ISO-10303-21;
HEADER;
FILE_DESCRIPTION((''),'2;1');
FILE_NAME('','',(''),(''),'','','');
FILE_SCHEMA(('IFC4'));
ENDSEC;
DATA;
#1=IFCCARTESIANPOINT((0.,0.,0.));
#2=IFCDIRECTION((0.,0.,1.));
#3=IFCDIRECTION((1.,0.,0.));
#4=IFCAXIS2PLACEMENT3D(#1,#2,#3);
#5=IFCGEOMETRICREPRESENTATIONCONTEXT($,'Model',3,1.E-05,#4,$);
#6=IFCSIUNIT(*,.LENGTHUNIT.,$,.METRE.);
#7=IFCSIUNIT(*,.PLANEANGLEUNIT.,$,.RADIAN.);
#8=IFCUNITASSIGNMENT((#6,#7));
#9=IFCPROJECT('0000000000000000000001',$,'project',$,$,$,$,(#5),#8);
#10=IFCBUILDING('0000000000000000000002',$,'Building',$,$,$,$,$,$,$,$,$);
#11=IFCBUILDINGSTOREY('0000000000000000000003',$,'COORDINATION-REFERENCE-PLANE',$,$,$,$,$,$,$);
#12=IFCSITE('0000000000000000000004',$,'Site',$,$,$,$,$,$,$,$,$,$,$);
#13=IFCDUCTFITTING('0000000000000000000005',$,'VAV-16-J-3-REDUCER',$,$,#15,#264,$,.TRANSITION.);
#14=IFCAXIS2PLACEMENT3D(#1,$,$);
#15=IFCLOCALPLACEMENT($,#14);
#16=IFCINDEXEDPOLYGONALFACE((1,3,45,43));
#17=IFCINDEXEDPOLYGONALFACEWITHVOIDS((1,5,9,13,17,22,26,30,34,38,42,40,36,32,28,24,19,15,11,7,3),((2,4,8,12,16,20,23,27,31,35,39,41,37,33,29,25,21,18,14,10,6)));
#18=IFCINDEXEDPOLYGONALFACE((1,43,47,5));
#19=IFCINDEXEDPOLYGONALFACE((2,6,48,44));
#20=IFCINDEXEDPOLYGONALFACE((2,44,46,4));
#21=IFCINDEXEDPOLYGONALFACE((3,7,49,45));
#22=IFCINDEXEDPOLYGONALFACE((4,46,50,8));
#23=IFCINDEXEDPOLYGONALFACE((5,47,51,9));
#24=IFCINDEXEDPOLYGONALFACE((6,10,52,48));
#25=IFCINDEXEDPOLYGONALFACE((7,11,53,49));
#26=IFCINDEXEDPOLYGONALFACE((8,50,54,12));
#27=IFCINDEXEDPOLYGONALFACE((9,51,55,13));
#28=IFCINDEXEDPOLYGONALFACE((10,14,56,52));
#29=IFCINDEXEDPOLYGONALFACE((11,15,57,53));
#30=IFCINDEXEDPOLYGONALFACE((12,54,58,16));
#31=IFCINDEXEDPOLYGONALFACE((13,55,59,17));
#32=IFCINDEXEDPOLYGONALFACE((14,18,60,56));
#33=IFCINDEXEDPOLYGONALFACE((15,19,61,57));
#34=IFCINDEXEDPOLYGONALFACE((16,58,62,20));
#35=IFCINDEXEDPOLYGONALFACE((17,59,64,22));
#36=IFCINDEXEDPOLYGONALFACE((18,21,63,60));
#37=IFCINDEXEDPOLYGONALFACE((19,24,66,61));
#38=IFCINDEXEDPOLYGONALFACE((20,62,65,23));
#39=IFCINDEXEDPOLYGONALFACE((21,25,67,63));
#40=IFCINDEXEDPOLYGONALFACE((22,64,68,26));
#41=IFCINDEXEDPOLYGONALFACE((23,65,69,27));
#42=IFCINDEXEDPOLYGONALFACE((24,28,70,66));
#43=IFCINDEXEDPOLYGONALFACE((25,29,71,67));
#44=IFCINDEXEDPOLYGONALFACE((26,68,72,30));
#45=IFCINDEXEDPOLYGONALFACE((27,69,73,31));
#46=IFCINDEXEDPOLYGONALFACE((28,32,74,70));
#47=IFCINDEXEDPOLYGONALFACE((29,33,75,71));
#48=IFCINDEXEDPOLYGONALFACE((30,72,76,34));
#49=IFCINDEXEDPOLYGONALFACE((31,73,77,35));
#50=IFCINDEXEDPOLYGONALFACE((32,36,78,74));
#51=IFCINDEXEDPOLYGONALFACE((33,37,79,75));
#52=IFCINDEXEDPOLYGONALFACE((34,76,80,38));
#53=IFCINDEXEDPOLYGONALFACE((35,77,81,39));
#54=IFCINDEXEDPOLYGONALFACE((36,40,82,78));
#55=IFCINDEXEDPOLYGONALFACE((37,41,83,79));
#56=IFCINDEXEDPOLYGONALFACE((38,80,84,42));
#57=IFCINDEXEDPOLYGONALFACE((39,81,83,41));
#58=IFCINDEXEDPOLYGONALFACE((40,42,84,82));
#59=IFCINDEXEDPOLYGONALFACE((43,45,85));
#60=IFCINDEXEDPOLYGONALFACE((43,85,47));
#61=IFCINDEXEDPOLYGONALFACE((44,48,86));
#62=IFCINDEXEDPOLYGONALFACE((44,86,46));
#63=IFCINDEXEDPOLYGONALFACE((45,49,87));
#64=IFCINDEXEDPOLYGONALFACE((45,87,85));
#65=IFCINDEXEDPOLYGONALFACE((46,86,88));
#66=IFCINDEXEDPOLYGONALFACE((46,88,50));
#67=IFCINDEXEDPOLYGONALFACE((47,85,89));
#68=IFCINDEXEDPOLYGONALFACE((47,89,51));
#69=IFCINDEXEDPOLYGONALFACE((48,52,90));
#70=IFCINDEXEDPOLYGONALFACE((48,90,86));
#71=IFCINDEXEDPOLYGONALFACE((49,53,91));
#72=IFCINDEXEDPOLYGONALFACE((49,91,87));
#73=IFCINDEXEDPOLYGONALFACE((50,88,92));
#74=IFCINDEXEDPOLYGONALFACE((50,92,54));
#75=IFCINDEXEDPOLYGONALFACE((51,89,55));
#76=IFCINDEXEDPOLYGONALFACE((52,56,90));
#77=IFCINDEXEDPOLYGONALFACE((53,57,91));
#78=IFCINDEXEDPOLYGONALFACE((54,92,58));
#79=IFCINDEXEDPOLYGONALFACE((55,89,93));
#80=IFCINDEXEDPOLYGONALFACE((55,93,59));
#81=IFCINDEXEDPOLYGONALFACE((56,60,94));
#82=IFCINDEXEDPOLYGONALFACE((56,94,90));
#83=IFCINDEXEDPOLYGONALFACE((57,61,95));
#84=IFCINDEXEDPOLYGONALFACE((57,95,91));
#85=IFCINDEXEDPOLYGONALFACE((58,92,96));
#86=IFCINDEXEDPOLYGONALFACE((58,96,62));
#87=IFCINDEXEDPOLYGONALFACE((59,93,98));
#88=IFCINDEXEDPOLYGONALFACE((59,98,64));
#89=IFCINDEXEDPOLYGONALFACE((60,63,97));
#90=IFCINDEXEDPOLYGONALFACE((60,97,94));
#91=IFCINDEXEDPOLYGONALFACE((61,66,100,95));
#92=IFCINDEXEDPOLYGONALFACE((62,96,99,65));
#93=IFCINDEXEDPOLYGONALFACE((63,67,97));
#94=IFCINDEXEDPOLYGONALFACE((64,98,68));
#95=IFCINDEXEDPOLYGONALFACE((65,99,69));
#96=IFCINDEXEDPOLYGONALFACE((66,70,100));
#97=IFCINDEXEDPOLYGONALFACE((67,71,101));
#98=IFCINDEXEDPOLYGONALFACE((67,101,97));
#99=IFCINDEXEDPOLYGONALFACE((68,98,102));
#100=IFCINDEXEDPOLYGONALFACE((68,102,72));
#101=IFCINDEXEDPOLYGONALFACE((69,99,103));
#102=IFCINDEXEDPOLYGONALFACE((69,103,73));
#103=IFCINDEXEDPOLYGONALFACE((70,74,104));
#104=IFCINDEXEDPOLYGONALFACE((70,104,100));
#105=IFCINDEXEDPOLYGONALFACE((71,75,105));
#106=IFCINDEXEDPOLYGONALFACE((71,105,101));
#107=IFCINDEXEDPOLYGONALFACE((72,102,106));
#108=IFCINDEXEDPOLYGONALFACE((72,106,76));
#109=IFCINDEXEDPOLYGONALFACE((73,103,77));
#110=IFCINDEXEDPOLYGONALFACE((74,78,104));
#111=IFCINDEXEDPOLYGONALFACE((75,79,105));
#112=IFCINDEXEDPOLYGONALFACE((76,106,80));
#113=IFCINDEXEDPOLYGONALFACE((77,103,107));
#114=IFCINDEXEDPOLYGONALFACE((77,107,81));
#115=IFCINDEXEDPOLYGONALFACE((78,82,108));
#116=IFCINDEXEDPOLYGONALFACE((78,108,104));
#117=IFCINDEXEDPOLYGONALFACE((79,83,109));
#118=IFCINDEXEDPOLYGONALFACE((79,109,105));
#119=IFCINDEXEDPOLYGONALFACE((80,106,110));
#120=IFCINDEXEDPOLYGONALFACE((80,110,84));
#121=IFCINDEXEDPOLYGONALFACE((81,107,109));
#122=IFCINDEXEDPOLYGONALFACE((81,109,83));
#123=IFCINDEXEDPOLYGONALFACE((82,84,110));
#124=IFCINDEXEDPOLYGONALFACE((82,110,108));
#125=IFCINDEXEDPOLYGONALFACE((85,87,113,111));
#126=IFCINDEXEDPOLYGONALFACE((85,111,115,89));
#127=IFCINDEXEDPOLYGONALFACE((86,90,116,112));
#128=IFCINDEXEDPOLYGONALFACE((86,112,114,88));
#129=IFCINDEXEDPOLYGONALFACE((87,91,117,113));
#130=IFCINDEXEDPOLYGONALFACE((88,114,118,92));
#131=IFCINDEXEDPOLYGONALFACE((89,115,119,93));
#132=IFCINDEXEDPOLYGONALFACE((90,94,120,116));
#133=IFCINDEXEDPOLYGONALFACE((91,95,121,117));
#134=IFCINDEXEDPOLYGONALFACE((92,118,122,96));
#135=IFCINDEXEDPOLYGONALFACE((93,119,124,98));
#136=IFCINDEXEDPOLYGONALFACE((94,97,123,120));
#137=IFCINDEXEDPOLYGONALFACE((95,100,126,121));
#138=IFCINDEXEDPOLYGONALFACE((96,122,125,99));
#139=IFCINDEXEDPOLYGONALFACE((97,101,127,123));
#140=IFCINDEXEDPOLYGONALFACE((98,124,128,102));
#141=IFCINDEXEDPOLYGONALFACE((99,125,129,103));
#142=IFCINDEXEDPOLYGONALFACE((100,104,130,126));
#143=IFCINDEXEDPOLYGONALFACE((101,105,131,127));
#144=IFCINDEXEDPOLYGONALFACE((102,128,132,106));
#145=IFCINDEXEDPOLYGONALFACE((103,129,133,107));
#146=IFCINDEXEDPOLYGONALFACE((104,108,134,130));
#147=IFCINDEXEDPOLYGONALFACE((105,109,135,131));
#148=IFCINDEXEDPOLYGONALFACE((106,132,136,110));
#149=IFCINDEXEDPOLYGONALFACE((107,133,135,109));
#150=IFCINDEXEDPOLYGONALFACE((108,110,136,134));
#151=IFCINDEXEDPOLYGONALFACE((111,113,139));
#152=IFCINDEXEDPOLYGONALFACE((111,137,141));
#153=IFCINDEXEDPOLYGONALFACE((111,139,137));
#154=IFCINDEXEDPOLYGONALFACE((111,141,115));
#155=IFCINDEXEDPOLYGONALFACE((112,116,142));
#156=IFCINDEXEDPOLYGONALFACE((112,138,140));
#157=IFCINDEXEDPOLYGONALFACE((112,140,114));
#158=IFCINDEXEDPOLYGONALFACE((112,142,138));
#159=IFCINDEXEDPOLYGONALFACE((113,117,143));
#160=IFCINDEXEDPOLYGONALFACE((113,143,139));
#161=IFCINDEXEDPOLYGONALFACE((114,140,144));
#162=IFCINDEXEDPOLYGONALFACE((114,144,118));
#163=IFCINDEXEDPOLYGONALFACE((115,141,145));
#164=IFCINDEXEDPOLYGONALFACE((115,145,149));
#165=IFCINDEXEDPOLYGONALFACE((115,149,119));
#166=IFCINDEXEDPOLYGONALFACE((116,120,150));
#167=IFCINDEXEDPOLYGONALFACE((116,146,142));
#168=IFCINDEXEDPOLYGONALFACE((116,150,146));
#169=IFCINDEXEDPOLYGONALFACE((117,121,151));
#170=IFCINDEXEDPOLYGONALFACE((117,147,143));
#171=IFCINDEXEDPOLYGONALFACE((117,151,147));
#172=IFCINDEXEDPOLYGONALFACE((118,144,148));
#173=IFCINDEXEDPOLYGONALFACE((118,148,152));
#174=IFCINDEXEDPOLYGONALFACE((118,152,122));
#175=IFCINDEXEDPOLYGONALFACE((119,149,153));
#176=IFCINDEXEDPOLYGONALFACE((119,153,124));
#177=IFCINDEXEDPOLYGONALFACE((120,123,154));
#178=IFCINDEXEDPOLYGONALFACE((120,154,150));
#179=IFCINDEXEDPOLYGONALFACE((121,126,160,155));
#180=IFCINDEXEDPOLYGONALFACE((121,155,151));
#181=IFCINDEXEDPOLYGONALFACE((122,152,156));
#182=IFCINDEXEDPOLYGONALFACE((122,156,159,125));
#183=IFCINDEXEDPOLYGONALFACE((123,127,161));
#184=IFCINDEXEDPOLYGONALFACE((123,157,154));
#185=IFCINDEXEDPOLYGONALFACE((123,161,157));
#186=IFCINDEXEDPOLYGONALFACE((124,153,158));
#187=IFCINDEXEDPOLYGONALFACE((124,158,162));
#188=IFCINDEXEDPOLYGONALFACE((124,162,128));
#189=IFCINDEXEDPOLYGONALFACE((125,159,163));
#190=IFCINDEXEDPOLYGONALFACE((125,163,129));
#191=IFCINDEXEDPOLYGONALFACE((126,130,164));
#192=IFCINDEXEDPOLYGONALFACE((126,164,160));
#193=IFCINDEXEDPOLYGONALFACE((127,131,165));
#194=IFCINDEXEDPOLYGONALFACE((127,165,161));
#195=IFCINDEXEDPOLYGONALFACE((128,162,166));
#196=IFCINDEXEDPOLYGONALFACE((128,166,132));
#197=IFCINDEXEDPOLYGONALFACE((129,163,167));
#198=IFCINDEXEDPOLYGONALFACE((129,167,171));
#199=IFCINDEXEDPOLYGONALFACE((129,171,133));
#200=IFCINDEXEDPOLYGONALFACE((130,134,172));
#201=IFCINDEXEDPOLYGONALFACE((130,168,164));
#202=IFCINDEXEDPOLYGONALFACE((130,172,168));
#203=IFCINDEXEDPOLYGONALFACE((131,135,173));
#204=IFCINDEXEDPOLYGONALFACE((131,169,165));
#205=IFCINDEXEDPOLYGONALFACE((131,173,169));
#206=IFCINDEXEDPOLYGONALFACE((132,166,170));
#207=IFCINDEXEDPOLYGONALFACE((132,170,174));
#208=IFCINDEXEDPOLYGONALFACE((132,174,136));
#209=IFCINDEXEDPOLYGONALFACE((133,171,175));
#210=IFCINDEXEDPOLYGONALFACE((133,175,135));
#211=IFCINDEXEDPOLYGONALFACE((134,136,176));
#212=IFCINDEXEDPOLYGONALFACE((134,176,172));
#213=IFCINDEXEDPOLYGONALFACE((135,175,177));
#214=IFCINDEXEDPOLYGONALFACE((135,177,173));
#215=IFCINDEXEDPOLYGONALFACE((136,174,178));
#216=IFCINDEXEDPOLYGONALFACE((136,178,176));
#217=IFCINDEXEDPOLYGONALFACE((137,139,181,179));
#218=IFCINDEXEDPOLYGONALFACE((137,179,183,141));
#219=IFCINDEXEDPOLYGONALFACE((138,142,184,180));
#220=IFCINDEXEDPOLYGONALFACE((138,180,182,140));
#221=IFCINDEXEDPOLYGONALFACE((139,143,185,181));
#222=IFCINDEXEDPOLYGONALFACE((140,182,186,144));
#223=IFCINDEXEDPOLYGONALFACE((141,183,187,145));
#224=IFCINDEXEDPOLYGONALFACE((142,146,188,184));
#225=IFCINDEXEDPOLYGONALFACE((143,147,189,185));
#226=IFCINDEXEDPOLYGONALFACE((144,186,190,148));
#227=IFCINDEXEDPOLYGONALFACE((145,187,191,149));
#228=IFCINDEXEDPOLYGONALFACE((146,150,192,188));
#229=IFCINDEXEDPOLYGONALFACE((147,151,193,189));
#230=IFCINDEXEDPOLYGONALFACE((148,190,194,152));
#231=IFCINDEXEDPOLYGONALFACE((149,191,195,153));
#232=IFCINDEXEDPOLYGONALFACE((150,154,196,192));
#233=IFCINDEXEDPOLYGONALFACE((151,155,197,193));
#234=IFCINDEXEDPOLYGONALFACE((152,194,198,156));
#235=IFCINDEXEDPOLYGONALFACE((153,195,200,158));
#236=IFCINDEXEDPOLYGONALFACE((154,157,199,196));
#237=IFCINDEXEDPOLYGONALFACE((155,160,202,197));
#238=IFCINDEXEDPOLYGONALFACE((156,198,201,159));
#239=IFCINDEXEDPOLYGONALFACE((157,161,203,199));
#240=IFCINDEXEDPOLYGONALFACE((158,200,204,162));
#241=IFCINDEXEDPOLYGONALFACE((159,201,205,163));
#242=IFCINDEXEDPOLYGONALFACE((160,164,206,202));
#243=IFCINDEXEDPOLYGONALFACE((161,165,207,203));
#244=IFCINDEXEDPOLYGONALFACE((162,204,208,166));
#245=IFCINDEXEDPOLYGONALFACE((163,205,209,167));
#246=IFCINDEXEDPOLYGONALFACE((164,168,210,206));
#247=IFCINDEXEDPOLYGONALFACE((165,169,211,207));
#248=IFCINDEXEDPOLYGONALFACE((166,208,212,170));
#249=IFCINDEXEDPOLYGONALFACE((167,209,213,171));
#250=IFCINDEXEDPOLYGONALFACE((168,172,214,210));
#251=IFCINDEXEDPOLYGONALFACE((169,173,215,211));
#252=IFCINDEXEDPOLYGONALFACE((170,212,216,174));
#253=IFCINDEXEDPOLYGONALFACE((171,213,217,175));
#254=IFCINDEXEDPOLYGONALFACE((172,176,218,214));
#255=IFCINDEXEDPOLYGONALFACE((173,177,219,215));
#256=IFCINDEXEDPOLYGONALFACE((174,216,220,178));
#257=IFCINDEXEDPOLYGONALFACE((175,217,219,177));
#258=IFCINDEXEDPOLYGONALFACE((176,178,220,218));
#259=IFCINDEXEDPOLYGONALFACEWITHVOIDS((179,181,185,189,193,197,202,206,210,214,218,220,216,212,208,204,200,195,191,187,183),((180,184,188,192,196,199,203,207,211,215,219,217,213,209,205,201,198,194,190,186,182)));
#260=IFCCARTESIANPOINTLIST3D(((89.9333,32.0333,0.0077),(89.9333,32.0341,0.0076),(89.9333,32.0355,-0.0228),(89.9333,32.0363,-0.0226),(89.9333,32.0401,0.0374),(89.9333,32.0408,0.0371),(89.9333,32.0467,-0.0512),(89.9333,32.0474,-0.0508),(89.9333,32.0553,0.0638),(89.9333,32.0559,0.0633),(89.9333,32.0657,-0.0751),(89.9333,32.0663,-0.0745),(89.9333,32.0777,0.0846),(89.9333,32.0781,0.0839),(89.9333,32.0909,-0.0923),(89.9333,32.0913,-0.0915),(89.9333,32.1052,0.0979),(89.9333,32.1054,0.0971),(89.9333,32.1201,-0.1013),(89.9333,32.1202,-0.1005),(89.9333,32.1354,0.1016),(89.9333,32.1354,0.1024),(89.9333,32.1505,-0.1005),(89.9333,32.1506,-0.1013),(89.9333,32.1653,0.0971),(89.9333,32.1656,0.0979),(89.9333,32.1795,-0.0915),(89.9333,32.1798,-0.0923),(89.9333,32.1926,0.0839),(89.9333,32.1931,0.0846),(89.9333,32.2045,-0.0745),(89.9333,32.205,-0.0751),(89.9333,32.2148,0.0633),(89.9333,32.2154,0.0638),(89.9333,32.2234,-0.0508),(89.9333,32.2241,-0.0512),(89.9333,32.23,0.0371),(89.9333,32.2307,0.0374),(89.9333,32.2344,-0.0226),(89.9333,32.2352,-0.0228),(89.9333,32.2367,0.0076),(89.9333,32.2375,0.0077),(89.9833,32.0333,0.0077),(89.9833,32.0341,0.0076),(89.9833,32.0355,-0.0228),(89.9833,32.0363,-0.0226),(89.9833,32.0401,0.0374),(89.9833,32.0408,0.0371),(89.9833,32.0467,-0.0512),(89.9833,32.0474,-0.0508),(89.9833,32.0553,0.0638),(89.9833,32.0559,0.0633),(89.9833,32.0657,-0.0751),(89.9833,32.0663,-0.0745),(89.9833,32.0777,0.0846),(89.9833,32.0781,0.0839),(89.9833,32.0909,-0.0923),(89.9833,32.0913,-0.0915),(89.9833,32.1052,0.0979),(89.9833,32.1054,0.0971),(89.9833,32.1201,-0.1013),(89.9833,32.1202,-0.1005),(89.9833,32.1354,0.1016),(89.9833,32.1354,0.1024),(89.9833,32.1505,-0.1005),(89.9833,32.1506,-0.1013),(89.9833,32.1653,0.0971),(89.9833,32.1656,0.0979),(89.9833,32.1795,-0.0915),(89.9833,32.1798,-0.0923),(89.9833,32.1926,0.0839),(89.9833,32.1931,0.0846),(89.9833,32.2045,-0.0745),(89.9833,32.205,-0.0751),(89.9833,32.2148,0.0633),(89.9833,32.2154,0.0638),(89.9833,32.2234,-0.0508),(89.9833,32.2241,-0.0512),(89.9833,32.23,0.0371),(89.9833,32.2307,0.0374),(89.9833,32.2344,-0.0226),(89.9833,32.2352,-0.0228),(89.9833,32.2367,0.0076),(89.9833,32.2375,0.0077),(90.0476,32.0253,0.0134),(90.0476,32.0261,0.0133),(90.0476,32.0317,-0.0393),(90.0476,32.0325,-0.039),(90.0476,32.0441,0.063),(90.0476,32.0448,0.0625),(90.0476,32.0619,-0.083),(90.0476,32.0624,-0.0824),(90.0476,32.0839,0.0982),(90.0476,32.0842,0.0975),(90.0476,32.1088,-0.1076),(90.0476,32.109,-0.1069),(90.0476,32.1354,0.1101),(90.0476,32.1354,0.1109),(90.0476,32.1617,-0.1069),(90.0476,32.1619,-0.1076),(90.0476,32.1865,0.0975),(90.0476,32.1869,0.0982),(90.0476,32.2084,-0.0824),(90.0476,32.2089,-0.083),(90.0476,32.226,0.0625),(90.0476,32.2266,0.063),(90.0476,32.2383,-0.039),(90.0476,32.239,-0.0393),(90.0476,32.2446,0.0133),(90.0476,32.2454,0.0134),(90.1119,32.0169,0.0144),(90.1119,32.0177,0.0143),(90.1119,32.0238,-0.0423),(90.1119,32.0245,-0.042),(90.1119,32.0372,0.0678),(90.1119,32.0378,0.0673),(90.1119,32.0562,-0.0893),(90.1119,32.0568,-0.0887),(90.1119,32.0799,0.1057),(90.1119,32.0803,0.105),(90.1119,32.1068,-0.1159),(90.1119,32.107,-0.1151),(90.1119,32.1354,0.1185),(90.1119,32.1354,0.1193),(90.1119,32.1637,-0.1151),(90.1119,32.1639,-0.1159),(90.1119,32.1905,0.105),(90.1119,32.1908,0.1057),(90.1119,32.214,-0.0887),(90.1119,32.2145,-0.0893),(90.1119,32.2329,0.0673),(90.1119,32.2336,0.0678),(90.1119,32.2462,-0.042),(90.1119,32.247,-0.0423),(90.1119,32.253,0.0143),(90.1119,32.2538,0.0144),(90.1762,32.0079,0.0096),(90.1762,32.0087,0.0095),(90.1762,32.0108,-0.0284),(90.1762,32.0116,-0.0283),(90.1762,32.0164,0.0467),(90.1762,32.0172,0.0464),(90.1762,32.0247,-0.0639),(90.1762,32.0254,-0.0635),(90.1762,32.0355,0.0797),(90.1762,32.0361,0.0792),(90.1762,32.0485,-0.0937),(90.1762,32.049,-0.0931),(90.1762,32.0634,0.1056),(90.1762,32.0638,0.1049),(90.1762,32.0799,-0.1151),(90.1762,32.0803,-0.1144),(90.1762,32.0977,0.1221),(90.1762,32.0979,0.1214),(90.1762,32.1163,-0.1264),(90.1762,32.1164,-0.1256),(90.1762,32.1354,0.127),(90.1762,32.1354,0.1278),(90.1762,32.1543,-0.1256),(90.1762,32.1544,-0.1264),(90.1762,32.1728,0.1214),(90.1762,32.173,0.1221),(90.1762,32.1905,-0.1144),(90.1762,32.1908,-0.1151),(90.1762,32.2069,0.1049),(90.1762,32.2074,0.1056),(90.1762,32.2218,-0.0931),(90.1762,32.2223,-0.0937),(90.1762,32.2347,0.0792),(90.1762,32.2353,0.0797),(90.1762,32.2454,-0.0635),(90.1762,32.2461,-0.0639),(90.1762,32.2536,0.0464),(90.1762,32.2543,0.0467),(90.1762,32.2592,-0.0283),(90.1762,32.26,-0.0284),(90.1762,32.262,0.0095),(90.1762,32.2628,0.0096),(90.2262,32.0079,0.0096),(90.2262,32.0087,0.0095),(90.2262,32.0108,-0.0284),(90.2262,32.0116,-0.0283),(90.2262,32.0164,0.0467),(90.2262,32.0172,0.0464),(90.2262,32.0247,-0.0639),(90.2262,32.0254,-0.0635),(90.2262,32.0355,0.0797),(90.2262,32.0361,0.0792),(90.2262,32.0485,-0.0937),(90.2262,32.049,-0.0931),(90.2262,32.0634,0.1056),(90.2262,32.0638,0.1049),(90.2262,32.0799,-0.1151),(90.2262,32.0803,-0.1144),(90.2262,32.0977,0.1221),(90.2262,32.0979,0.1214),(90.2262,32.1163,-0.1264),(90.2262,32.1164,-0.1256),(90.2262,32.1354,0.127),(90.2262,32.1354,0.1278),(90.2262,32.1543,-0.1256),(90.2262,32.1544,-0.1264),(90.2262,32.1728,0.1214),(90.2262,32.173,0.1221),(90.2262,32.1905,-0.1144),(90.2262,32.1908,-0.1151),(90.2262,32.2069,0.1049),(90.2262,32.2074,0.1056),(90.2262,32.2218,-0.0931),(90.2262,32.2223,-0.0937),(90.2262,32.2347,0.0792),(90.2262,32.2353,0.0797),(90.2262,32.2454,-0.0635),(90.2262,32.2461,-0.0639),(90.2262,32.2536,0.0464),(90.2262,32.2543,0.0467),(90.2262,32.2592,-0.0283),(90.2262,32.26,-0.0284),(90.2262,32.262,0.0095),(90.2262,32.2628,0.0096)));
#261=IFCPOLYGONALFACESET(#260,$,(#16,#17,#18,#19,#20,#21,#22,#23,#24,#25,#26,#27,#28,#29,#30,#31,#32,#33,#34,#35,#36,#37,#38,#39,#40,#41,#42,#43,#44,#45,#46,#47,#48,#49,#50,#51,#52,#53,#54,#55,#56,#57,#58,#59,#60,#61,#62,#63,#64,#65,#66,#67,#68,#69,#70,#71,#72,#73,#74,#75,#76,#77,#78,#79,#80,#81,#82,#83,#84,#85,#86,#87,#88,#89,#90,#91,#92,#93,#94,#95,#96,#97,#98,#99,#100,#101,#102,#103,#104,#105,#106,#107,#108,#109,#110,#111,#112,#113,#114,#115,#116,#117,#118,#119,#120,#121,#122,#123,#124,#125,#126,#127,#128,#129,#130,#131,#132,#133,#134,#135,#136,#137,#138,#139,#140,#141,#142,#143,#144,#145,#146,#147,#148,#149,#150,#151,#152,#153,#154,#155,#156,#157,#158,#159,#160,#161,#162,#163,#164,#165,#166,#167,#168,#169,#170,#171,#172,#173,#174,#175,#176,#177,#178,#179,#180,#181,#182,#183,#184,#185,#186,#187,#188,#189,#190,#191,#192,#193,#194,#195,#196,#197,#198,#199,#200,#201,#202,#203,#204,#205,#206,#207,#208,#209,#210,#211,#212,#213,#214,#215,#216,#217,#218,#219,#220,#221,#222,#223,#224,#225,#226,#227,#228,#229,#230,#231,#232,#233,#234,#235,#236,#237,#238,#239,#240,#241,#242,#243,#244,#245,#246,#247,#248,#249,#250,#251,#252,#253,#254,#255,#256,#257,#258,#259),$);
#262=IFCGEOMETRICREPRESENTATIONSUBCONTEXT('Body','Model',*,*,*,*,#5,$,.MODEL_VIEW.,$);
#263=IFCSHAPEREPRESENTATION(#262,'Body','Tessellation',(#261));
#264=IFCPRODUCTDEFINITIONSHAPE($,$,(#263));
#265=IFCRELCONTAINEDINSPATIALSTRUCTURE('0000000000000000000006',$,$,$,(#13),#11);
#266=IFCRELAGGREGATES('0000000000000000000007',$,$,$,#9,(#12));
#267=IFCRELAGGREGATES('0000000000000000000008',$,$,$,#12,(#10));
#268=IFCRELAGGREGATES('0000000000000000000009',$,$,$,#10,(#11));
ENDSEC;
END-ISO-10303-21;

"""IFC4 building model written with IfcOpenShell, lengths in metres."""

from ifc_helpers import new_model, entity, si_unit, frame, origin_with_axes, place, context, subcontext, project, spatial, element, save


model = new_model("IFC4")

# Units and contexts
model_context = context("Model", 3, precision=1e-05, world=origin_with_axes())
body_context_1 = subcontext(model_context, "Body", "Model", "MODEL_VIEW")
ifc_project = project(units=[si_unit("LENGTHUNIT", "METRE"), si_unit("PLANEANGLEUNIT", "RADIAN")], contexts=[model_context])

# Site, building, storey
site = spatial("IfcSite", under=ifc_project, Name="Site")
building = spatial("IfcBuilding", under=site, Name="Building")
storey = spatial("IfcBuildingStorey", under=building, Name="COORDINATION-REFERENCE-PLANE")

# Duct fitting
for number, where, z_axis, x_axis, name in (
    (1, (90.2262, 32.1354, 0.0), (0.0, -1.0, 0.0), (0.0, 0.0, 1.0), "VAV-16-J-3-REDUCER"),
):
    element("IfcDuctFitting", number, at=place(None, frame(where, z_axis=z_axis, x_axis=x_axis)), inside=storey, Name=name, PredefinedType="TRANSITION", context=body_context_1, shape_type="SweptSolid", body=[
        entity("IfcRevolvedAreaSolid", entity("IfcArbitraryClosedProfileDef", "AREA", None, entity("IfcPolyline", [entity("IfcCartesianPoint", [0.1278, 0.0]), entity("IfcCartesianPoint", [0.1278, 0.05]), entity("IfcCartesianPoint", [0.1024, 0.2429]), entity("IfcCartesianPoint", [0.1024, 0.2929]), entity("IfcCartesianPoint", [0.1016, 0.2929]), entity("IfcCartesianPoint", [0.1016, 0.2429]), entity("IfcCartesianPoint", [0.127, 0.05]), entity("IfcCartesianPoint", [0.127, 0.0]), entity("IfcCartesianPoint", [0.1278, 0.0])])), entity("IfcAxis2Placement3D", entity("IfcCartesianPoint", [0.0, 0.0, 0.0])), entity("IfcAxis1Placement", entity("IfcCartesianPoint", [0.0, 0.0, 0.0]), entity("IfcDirection", [0.0, 1.0, 0.0])), 6.283185),
    ])

save(model, "model.ifc")
